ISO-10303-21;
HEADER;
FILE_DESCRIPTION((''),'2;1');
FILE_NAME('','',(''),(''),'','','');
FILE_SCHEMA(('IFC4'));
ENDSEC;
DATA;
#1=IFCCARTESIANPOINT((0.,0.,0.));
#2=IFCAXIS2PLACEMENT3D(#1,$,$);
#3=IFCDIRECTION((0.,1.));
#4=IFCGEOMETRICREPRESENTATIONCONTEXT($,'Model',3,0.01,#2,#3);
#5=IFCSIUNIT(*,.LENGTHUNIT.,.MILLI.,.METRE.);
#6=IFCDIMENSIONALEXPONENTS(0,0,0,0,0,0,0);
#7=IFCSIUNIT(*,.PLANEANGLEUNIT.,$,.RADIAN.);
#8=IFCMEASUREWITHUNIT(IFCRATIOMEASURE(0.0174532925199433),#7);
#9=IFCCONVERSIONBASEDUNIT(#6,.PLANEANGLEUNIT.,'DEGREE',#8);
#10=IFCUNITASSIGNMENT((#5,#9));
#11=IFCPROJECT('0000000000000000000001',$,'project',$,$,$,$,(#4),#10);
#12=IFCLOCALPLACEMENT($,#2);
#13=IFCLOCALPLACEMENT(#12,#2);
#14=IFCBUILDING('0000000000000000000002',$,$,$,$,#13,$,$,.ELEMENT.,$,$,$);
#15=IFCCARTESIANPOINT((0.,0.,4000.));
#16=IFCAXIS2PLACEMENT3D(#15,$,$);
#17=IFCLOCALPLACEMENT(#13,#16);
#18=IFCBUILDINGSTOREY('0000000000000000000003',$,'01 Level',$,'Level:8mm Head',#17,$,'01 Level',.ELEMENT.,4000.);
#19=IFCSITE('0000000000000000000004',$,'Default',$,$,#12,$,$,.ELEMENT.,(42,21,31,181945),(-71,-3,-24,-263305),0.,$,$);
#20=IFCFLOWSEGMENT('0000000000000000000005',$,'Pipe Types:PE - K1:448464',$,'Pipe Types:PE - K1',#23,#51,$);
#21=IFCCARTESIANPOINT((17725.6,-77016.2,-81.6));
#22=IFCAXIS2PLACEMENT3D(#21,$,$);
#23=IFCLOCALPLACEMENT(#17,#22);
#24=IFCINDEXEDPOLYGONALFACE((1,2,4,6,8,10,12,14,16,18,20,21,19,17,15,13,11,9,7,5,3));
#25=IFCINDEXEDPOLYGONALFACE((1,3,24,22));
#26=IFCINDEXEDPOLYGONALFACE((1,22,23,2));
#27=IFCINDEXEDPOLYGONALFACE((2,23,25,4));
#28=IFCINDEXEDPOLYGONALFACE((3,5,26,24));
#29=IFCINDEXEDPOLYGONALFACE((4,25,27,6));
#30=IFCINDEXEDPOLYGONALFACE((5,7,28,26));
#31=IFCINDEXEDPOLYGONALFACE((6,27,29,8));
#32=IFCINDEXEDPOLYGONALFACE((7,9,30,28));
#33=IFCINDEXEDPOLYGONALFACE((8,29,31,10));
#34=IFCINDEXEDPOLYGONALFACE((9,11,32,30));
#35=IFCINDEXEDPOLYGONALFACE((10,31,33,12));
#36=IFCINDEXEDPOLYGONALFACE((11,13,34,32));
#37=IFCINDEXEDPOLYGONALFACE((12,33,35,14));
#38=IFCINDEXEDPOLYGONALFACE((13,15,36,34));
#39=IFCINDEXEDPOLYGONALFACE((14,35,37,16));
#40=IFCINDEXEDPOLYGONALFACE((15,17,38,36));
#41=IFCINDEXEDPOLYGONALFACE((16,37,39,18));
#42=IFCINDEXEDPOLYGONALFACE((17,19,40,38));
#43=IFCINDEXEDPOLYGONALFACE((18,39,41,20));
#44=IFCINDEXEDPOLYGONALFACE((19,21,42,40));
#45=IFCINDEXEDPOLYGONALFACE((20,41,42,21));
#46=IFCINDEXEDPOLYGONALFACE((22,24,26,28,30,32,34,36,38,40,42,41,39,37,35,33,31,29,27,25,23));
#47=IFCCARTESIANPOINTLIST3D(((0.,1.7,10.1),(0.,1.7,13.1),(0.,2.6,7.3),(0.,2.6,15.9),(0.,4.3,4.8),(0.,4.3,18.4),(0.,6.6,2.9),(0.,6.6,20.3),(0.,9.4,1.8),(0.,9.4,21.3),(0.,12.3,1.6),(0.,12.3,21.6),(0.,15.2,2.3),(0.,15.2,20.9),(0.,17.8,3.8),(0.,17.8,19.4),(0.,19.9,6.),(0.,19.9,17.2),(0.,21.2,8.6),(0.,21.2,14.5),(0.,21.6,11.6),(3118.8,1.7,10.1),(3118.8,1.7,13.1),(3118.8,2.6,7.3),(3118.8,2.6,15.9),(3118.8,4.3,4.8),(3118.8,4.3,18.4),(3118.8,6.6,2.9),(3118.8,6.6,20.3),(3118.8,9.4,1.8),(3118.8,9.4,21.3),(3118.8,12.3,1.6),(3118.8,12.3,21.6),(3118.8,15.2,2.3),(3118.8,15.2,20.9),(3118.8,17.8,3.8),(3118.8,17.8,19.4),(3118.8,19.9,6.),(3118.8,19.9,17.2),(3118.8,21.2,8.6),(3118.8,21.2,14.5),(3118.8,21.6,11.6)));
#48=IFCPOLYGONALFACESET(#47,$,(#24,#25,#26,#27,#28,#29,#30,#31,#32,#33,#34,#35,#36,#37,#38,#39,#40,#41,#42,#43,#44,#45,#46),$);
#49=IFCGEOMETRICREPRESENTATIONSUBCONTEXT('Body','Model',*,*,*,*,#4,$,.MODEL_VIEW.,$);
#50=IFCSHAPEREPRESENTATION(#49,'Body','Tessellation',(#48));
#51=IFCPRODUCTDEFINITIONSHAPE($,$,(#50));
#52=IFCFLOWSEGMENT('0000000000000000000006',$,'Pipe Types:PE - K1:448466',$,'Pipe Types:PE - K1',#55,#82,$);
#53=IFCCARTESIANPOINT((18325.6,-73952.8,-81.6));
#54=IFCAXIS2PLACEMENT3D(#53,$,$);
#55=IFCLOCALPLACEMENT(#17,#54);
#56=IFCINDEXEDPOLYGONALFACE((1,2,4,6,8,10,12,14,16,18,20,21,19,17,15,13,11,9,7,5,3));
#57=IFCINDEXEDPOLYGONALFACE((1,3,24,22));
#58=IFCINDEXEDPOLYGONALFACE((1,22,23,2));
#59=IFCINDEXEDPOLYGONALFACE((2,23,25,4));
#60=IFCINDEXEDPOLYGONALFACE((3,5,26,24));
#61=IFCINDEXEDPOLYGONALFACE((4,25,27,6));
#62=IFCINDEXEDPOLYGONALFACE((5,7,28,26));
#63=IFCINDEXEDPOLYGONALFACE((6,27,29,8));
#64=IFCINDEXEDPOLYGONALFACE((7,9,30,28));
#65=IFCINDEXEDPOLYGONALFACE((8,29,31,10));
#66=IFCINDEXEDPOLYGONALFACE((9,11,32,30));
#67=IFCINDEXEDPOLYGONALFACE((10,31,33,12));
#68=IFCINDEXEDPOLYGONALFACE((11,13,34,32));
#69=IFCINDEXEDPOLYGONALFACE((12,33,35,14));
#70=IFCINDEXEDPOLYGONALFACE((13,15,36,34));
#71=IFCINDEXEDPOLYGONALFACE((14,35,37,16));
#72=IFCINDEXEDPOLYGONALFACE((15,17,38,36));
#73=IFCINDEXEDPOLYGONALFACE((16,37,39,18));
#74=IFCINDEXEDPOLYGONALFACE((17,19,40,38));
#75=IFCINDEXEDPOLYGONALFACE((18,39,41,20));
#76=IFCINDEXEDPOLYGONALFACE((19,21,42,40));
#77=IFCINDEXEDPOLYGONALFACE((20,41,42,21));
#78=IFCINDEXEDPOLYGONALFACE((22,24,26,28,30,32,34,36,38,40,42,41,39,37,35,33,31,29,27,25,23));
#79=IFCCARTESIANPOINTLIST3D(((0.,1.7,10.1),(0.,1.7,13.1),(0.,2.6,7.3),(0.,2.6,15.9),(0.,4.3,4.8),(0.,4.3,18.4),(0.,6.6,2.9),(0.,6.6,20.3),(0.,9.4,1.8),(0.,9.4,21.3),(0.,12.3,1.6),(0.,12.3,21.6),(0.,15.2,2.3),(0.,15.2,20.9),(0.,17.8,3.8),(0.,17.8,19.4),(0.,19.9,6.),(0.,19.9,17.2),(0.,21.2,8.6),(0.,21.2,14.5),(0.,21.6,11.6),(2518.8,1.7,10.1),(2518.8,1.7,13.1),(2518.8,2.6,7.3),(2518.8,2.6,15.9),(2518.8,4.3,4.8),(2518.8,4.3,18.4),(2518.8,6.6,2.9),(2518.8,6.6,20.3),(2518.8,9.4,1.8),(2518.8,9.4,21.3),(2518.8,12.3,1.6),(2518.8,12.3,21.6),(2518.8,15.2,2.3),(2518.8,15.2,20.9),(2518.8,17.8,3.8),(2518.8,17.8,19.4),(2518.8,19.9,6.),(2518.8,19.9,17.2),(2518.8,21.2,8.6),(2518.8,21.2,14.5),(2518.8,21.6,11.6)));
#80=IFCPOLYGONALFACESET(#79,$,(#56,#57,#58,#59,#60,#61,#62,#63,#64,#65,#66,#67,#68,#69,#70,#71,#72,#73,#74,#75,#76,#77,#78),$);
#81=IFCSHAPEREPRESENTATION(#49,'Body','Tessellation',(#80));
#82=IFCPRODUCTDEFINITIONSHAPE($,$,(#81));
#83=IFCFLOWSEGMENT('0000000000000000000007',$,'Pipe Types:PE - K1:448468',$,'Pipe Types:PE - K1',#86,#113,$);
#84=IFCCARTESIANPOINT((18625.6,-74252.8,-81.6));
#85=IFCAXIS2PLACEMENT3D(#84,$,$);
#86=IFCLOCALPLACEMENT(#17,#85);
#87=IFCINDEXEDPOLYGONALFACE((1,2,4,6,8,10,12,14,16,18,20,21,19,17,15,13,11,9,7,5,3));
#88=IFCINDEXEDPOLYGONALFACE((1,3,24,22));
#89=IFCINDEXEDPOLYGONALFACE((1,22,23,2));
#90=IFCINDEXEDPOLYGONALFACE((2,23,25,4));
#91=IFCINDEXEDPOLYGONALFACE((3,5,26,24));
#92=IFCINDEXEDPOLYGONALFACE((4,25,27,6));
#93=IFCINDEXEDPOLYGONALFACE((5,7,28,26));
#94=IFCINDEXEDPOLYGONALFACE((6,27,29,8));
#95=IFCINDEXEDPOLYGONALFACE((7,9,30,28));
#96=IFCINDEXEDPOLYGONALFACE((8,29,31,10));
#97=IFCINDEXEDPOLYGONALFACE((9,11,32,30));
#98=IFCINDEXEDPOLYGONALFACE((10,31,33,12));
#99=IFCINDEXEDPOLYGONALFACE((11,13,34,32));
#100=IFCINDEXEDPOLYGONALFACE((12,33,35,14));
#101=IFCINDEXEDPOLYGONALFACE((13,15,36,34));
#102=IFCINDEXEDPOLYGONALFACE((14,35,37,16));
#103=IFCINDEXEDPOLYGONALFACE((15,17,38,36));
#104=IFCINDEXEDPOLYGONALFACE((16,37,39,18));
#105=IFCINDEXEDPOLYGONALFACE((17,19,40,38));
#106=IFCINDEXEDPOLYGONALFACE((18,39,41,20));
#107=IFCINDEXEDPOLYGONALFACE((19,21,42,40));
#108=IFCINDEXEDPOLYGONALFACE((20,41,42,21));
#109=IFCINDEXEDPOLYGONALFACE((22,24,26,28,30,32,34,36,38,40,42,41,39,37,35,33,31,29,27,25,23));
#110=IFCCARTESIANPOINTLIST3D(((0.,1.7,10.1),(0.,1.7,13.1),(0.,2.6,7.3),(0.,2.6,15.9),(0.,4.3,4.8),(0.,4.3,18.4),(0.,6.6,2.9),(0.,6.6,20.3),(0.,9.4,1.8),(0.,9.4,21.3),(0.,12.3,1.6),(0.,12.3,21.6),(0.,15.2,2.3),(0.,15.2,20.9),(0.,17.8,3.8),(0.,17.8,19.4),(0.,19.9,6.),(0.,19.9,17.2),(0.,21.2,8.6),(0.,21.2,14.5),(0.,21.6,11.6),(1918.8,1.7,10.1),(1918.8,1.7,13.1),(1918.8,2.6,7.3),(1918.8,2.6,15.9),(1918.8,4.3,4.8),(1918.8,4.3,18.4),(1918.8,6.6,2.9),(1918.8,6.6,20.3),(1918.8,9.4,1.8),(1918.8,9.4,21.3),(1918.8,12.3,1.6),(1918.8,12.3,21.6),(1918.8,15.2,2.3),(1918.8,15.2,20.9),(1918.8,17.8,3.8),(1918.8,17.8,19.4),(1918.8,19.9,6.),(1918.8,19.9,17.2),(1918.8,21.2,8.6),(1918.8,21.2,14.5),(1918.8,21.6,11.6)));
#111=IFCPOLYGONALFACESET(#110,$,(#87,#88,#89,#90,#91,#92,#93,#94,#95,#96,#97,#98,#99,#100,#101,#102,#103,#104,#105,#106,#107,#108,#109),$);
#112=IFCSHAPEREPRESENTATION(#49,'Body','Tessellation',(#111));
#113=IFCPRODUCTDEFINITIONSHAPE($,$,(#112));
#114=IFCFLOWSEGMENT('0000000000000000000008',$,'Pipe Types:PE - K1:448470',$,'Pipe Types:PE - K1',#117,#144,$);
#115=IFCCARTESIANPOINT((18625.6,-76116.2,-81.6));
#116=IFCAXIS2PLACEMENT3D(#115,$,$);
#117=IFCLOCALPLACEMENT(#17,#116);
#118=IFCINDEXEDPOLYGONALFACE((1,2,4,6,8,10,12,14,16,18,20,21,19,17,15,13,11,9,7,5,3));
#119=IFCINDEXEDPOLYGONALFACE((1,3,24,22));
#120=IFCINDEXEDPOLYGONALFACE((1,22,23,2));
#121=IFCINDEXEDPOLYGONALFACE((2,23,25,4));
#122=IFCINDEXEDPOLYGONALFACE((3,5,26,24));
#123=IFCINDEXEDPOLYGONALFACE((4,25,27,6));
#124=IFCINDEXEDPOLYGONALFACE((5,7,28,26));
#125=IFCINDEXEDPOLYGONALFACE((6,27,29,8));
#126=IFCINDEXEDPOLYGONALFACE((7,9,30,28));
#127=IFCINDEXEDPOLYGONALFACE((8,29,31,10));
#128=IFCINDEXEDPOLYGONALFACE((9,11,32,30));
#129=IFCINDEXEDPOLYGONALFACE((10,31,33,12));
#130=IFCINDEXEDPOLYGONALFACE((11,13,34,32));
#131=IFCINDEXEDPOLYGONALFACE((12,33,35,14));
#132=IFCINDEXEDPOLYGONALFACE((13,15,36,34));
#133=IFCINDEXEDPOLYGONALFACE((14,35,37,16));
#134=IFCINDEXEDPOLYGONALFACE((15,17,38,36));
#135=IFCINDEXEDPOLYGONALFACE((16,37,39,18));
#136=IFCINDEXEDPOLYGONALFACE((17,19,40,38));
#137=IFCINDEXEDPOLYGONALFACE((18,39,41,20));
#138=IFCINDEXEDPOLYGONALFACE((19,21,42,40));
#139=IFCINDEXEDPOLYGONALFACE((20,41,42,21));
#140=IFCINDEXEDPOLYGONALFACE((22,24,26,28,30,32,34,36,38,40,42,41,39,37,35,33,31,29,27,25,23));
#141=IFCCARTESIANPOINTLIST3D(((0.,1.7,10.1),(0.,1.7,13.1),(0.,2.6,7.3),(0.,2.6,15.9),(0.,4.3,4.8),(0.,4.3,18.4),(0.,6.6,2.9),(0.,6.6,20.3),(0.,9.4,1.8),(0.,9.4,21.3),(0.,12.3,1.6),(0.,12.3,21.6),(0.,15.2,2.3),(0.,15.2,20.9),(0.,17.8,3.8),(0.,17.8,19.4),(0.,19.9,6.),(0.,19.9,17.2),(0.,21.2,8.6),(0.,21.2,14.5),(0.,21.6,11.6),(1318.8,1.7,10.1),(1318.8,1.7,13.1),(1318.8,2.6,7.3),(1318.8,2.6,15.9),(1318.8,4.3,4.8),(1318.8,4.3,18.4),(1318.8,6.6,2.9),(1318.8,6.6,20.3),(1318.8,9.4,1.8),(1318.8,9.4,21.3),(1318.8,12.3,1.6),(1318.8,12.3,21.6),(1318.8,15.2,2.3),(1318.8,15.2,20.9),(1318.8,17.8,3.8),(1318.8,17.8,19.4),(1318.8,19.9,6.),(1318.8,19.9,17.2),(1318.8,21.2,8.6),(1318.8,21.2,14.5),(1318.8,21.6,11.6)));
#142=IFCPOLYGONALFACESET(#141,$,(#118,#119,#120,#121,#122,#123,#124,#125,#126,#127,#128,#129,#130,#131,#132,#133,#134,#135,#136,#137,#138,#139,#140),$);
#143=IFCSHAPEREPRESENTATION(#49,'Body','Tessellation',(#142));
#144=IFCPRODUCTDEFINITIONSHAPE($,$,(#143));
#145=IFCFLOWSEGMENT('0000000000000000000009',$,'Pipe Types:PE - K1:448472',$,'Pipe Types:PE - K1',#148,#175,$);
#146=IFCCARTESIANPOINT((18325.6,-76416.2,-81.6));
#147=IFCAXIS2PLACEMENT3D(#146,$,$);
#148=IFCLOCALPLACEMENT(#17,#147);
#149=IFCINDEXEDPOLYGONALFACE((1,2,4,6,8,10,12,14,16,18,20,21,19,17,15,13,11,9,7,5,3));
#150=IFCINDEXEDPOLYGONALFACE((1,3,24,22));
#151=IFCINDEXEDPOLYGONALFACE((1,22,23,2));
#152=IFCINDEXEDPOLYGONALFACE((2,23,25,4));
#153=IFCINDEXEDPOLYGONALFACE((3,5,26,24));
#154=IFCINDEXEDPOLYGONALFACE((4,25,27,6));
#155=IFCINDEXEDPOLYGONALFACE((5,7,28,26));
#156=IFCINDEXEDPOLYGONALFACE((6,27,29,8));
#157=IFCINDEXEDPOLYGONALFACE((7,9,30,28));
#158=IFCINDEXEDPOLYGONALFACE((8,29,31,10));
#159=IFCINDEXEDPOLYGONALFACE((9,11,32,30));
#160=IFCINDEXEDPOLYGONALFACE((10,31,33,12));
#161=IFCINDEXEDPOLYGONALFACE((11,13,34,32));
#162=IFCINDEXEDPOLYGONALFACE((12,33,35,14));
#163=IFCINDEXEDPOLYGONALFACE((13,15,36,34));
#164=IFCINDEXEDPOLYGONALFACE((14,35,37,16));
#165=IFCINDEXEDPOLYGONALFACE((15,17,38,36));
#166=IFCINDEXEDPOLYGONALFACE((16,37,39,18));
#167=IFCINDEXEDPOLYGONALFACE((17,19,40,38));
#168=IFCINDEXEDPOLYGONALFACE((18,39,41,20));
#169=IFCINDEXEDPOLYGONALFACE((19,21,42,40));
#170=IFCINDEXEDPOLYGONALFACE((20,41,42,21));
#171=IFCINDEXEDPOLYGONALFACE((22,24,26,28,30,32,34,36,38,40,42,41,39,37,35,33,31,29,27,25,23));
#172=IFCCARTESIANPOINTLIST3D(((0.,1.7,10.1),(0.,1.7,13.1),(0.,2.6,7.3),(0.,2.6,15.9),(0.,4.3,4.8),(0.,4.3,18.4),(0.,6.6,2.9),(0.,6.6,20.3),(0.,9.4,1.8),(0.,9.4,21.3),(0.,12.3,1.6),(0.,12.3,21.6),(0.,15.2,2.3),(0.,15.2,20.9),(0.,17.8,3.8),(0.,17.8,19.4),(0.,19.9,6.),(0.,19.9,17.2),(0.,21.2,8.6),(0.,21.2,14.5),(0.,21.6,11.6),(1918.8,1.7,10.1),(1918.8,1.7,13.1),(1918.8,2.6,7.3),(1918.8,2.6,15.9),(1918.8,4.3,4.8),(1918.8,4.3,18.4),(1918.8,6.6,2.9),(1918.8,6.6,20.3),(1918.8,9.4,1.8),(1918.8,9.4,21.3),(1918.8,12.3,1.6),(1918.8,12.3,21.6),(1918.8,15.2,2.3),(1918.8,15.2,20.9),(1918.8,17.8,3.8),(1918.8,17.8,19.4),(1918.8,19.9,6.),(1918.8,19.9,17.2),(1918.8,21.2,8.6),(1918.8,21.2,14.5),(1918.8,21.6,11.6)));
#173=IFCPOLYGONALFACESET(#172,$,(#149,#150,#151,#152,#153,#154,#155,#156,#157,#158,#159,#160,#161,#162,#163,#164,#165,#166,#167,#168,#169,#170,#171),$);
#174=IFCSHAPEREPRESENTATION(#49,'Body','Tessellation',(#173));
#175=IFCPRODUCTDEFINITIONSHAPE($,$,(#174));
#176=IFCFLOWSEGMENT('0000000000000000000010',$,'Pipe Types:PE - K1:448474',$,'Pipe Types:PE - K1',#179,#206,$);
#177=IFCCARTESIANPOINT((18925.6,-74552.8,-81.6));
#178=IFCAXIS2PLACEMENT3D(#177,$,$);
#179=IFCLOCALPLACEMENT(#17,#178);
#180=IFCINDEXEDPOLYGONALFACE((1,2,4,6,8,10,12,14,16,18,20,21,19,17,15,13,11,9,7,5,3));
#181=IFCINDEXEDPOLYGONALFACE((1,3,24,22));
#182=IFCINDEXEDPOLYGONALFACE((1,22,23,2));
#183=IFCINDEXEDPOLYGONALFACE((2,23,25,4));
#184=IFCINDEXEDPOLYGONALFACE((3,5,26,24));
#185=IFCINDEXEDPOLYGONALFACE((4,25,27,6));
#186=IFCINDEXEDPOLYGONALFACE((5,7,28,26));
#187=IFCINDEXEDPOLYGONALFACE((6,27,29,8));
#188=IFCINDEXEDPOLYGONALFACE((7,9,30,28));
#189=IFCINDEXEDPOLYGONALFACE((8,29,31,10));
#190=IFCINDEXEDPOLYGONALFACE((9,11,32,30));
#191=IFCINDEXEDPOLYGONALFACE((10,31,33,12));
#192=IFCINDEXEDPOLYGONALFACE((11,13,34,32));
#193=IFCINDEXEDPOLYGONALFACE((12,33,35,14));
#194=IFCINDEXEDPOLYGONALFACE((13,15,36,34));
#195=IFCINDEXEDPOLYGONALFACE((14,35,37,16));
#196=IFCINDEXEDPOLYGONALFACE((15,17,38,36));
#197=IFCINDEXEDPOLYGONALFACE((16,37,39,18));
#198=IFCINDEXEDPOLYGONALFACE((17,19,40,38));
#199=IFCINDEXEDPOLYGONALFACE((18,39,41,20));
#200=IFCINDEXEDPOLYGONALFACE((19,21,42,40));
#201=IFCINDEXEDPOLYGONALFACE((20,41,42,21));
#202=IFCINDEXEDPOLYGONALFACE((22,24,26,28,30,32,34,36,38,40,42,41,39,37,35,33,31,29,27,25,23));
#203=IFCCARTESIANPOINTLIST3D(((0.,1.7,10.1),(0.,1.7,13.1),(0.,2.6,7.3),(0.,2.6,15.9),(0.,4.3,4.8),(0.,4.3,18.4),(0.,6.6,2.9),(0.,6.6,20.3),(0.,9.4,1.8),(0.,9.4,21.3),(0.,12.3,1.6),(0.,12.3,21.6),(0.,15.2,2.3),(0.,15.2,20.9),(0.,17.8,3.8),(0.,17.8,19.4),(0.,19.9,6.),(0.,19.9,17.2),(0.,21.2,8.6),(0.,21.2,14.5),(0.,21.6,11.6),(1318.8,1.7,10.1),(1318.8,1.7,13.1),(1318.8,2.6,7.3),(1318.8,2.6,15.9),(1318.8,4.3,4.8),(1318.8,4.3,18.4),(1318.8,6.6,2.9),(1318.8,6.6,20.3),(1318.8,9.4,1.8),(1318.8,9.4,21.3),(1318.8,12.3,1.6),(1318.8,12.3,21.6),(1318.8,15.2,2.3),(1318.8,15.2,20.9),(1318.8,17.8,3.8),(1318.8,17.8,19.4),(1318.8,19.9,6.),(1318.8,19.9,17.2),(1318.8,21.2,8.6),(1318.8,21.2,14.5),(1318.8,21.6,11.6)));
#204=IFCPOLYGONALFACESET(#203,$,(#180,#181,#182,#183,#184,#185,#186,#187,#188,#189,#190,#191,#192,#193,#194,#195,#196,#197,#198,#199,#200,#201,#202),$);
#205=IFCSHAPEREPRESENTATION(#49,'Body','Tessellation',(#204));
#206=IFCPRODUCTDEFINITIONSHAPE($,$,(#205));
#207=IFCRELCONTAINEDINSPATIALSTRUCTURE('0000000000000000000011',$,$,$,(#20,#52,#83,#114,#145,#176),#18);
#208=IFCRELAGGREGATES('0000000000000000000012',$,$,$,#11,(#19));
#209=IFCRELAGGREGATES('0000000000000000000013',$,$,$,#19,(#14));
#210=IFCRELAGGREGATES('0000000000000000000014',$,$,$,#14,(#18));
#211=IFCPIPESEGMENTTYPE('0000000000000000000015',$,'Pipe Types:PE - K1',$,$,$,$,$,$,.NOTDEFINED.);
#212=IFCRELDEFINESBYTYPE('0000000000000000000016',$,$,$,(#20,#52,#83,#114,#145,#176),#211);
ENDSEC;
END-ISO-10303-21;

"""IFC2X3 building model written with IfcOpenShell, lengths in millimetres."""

from ifc_helpers import new_model, entity, si_unit, converted_unit, direction, frame, frame_2d, origin, origin_2d_with_axis, place, context, subcontext, project, spatial, circle, extrude, type_object, element, save


model = new_model("IFC2X3")

# Units and contexts
model_context = context("Model", 3, precision=0.01, world=origin(), true_north=direction((0.0, 1.0)))
body_context = subcontext(model_context, "Body", "Model", "MODEL_VIEW")
ifc_project = project(units=[si_unit("LENGTHUNIT", "METRE", prefix="MILLI"), converted_unit("PLANEANGLEUNIT", "DEGREE", entity("IfcRatioMeasure", 0.0174532925199433), si_unit("PLANEANGLEUNIT", "RADIAN"), dimensions=[0, 0, 0, 0, 0, 0, 0])], contexts=[model_context])

# Site, building, storey
site_placement = place(None, origin())
site = spatial("IfcSite", under=ifc_project, at=site_placement, Name="Default", CompositionType="ELEMENT", RefLatitude=(42, 21, 31, 181945), RefLongitude=(-71, -3, -24, -263305), RefElevation=0.0)
building_placement = place(site_placement, origin())
building = spatial("IfcBuilding", under=site, at=building_placement, CompositionType="ELEMENT")
storey_placement = place(building_placement, frame((0.0, 0.0, 4000.0)))
storey = spatial("IfcBuildingStorey", under=building, at=storey_placement, Name="01 Level", ObjectType="Level:8mm Head", LongName="01 Level", CompositionType="ELEMENT", Elevation=4000.0)

# Flow segments
pipe_segment_type = type_object("IfcPipeSegmentType", Name="Pipe Types:PE - K1", PredefinedType="NOTDEFINED")
flow_segment_1_placement = place(storey_placement, frame((17725.6, -77016.2, -81.6)))
element("IfcFlowSegment", 1, at=flow_segment_1_placement, inside=storey, type_object=pipe_segment_type, Name="Pipe Types:PE - K1:448464", ObjectType="Pipe Types:PE - K1", context=body_context, shape_type="SweptSolid", body=[
    extrude(circle(Radius=10.0, at=frame_2d((0.0, 0.0), x_axis=(1.0, 0.0))), frame((0.0, 11.6, 11.6), z_axis=(1.0, 0.0, 0.0), x_axis=(0.0, 1.0, 0.0)), (0.0, 0.0, 1.0), 3118.8),
])
flow_segment_2_placement = place(storey_placement, frame((18325.6, -73952.8, -81.6)))
element("IfcFlowSegment", 2, at=flow_segment_2_placement, inside=storey, type_object=pipe_segment_type, Name="Pipe Types:PE - K1:448466", ObjectType="Pipe Types:PE - K1", context=body_context, shape_type="SweptSolid", body=[
    extrude(circle(Radius=10.0, at=frame_2d((0.0, 0.0), x_axis=(1.0, 0.0))), frame((0.0, 11.6, 11.6), z_axis=(1.0, 0.0, 0.0), x_axis=(0.0, 1.0, 0.0)), (0.0, 0.0, 1.0), 2518.8),
])
flow_segment_3_placement = place(storey_placement, frame((18625.6, -74252.8, -81.6)))
element("IfcFlowSegment", 3, at=flow_segment_3_placement, inside=storey, type_object=pipe_segment_type, Name="Pipe Types:PE - K1:448468", ObjectType="Pipe Types:PE - K1", context=body_context, shape_type="SweptSolid", body=[
    extrude(circle(Radius=10.0, at=frame_2d((0.0, 0.0), x_axis=(1.0, 0.0))), frame((0.0, 11.6, 11.6), z_axis=(1.0, 0.0, 0.0), x_axis=(0.0, 1.0, 0.0)), (0.0, 0.0, 1.0), 1918.8),
])
flow_segment_4_placement = place(storey_placement, frame((18625.6, -76116.2, -81.6)))
element("IfcFlowSegment", 4, at=flow_segment_4_placement, inside=storey, type_object=pipe_segment_type, Name="Pipe Types:PE - K1:448470", ObjectType="Pipe Types:PE - K1", context=body_context, shape_type="SweptSolid", body=[
    extrude(circle(Radius=10.0, at=origin_2d_with_axis()), frame((0.0, 11.6, 11.6), z_axis=(1.0, 0.0, 0.0), x_axis=(0.0, 1.0, 0.0)), (0.0, 0.0, 1.0), 1318.8),
])
flow_segment_5_placement = place(storey_placement, frame((18325.6, -76416.2, -81.6)))
element("IfcFlowSegment", 5, at=flow_segment_5_placement, inside=storey, type_object=pipe_segment_type, Name="Pipe Types:PE - K1:448472", ObjectType="Pipe Types:PE - K1", context=body_context, shape_type="SweptSolid", body=[
    extrude(circle(Radius=10.0, at=frame_2d((0.0, 0.0), x_axis=(1.0, 0.0))), frame((0.0, 11.6, 11.6), z_axis=(1.0, 0.0, 0.0), x_axis=(0.0, 1.0, 0.0)), (0.0, 0.0, 1.0), 1918.8),
])
flow_segment_6_placement = place(storey_placement, frame((18925.6, -74552.8, -81.6)))
element("IfcFlowSegment", 6, at=flow_segment_6_placement, inside=storey, type_object=pipe_segment_type, Name="Pipe Types:PE - K1:448474", ObjectType="Pipe Types:PE - K1", context=body_context, shape_type="SweptSolid", body=[
    extrude(circle(Radius=10.0, at=frame_2d((0.0, 0.0), x_axis=(1.0, 0.0))), frame((0.0, 11.6, 11.6), z_axis=(1.0, 0.0, 0.0), x_axis=(0.0, 1.0, 0.0)), (0.0, 0.0, 1.0), 1318.8),
])

save(model, "model.ifc")
